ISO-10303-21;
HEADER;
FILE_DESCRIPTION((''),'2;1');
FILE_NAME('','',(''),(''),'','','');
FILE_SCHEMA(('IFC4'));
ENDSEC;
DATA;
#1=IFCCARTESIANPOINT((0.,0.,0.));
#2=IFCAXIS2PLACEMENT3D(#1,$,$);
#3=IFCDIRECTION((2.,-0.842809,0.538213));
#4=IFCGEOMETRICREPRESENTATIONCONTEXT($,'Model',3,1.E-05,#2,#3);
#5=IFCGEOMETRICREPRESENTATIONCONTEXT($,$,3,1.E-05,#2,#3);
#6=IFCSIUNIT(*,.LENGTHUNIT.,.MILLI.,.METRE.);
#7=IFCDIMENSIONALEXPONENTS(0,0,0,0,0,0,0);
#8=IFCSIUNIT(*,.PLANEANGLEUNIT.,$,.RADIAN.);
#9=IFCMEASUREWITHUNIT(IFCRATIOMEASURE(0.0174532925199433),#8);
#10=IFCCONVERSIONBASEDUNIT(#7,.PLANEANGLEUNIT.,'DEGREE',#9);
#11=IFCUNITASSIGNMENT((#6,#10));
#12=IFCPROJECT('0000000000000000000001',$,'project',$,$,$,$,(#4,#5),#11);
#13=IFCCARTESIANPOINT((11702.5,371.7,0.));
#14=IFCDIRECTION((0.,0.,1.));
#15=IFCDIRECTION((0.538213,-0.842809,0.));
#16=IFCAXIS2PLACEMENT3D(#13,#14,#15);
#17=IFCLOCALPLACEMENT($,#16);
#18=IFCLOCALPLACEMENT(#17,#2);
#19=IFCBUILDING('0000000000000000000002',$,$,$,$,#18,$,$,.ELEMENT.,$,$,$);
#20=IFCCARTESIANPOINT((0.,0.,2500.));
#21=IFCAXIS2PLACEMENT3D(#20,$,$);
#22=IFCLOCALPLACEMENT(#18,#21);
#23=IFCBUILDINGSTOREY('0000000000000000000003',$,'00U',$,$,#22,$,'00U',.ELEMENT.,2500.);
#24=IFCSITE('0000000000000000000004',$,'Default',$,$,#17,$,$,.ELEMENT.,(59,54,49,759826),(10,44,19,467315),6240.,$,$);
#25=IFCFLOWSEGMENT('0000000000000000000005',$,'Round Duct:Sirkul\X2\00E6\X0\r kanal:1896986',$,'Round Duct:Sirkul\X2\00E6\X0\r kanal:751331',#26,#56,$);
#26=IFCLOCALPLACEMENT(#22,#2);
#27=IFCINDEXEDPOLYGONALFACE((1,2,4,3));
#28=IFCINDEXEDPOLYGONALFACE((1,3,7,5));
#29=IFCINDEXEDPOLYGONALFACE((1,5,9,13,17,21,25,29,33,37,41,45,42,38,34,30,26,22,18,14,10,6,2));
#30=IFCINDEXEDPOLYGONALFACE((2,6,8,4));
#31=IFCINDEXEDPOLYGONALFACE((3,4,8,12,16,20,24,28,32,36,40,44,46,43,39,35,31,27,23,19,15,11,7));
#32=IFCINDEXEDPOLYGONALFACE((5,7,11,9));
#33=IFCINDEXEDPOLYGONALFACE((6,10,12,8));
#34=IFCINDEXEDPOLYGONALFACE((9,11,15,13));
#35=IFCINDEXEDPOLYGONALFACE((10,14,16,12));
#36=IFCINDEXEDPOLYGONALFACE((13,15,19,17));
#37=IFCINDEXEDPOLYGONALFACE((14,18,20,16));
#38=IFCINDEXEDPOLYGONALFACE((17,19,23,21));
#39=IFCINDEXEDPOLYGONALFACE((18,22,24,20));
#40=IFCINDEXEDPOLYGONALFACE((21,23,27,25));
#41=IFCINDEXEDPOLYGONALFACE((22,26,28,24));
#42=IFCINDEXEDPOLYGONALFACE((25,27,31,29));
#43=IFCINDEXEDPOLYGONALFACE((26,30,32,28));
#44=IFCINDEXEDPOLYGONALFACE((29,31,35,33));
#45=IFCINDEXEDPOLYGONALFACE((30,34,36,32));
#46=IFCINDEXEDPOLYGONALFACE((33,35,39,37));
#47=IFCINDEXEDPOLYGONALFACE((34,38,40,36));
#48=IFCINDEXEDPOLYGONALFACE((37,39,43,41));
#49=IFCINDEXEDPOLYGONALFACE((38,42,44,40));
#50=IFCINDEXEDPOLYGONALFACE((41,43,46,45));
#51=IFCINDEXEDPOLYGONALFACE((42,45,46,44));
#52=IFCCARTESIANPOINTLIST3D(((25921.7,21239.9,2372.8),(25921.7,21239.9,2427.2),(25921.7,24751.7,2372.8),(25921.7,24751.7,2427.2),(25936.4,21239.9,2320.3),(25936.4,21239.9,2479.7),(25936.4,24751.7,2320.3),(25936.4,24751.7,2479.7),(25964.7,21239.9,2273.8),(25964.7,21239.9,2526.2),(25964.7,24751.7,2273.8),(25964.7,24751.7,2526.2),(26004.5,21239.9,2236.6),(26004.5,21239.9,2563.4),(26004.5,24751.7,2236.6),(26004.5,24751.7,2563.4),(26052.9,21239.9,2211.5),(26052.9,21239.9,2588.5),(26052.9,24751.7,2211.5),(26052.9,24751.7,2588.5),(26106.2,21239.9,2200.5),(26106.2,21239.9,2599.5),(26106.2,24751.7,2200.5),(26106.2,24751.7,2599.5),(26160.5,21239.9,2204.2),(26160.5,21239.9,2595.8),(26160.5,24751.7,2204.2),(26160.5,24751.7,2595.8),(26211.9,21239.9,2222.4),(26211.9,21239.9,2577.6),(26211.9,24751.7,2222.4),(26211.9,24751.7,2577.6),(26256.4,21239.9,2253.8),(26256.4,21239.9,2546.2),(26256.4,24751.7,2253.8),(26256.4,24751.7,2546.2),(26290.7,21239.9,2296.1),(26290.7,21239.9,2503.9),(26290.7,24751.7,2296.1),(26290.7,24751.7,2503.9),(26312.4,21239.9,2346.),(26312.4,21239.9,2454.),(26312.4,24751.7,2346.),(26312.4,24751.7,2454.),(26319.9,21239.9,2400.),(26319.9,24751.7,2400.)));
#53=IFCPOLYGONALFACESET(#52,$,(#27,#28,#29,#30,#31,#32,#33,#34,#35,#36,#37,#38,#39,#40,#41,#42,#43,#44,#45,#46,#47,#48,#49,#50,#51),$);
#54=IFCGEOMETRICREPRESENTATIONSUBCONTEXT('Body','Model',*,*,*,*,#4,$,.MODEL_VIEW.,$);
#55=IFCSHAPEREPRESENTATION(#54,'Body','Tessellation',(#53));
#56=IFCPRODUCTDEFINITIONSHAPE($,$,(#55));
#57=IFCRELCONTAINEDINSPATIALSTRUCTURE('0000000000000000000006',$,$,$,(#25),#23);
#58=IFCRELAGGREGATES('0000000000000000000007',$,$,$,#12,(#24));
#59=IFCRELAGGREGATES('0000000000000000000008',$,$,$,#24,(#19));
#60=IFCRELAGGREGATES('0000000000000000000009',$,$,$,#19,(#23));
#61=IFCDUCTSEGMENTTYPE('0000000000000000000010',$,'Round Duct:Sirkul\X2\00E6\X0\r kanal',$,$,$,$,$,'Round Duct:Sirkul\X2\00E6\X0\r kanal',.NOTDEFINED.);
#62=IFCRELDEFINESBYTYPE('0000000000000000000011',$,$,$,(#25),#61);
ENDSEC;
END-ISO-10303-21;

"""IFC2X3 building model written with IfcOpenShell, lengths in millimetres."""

from ifc_helpers import new_model, entity, si_unit, converted_unit, direction, frame, origin, origin_2d_with_axis, place, context, subcontext, project, spatial, circle, extrude, type_object, element, save


model = new_model("IFC2X3")

# Units and contexts
model_context = context("Model", 3, precision=1e-05, world=origin(), true_north=direction((2.0, -0.842809, 0.538213)))
context_of_model = context(None, 3, precision=1e-05, world=origin(), true_north=direction((2.0, -0.842809, 0.538213)))
body_context = subcontext(model_context, "Body", "Model", "MODEL_VIEW")
ifc_project = project(units=[si_unit("LENGTHUNIT", "METRE", prefix="MILLI"), converted_unit("PLANEANGLEUNIT", "DEGREE", entity("IfcRatioMeasure", 0.0174532925199433), si_unit("PLANEANGLEUNIT", "RADIAN"), dimensions=[0, 0, 0, 0, 0, 0, 0])], contexts=[model_context, context_of_model])

# Site, building, storey
site_placement = place(None, frame((11702.5, 371.7, 0.0), z_axis=(0.0, 0.0, 1.0), x_axis=(0.538213, -0.842809, 0.0)))
site = spatial("IfcSite", under=ifc_project, at=site_placement, Name="Default", CompositionType="ELEMENT", RefLatitude=(59, 54, 49, 759826), RefLongitude=(10, 44, 19, 467315), RefElevation=6240.0)
building_placement = place(site_placement, origin())
building = spatial("IfcBuilding", under=site, at=building_placement, CompositionType="ELEMENT")
storey_placement = place(building_placement, frame((0.0, 0.0, 2500.0)))
storey = spatial("IfcBuildingStorey", under=building, at=storey_placement, Name="00U", LongName="00U", CompositionType="ELEMENT", Elevation=2500.0)

# Flow segment
duct_segment_type_1 = type_object("IfcDuctSegmentType", Name="Round Duct:Sirkulær kanal", ElementType="Round Duct:Sirkulær kanal", PredefinedType="NOTDEFINED")
flow_segment_1_placement = place(storey_placement, origin())
element("IfcFlowSegment", 1, at=flow_segment_1_placement, inside=storey, type_object=duct_segment_type_1, Name="Round Duct:Sirkulær kanal:1896986", ObjectType="Round Duct:Sirkulær kanal:751331", context=body_context, shape_type="SweptSolid", body=[
    extrude(circle(Radius=200.0, at=origin_2d_with_axis()), frame((26119.9, 21239.9, 2400.0), z_axis=(0.0, 1.0, 0.0), x_axis=(1.0, 0.0, 0.0)), (0.0, 0.0, 1.0), 3511.7),
])

save(model, "model.ifc")
